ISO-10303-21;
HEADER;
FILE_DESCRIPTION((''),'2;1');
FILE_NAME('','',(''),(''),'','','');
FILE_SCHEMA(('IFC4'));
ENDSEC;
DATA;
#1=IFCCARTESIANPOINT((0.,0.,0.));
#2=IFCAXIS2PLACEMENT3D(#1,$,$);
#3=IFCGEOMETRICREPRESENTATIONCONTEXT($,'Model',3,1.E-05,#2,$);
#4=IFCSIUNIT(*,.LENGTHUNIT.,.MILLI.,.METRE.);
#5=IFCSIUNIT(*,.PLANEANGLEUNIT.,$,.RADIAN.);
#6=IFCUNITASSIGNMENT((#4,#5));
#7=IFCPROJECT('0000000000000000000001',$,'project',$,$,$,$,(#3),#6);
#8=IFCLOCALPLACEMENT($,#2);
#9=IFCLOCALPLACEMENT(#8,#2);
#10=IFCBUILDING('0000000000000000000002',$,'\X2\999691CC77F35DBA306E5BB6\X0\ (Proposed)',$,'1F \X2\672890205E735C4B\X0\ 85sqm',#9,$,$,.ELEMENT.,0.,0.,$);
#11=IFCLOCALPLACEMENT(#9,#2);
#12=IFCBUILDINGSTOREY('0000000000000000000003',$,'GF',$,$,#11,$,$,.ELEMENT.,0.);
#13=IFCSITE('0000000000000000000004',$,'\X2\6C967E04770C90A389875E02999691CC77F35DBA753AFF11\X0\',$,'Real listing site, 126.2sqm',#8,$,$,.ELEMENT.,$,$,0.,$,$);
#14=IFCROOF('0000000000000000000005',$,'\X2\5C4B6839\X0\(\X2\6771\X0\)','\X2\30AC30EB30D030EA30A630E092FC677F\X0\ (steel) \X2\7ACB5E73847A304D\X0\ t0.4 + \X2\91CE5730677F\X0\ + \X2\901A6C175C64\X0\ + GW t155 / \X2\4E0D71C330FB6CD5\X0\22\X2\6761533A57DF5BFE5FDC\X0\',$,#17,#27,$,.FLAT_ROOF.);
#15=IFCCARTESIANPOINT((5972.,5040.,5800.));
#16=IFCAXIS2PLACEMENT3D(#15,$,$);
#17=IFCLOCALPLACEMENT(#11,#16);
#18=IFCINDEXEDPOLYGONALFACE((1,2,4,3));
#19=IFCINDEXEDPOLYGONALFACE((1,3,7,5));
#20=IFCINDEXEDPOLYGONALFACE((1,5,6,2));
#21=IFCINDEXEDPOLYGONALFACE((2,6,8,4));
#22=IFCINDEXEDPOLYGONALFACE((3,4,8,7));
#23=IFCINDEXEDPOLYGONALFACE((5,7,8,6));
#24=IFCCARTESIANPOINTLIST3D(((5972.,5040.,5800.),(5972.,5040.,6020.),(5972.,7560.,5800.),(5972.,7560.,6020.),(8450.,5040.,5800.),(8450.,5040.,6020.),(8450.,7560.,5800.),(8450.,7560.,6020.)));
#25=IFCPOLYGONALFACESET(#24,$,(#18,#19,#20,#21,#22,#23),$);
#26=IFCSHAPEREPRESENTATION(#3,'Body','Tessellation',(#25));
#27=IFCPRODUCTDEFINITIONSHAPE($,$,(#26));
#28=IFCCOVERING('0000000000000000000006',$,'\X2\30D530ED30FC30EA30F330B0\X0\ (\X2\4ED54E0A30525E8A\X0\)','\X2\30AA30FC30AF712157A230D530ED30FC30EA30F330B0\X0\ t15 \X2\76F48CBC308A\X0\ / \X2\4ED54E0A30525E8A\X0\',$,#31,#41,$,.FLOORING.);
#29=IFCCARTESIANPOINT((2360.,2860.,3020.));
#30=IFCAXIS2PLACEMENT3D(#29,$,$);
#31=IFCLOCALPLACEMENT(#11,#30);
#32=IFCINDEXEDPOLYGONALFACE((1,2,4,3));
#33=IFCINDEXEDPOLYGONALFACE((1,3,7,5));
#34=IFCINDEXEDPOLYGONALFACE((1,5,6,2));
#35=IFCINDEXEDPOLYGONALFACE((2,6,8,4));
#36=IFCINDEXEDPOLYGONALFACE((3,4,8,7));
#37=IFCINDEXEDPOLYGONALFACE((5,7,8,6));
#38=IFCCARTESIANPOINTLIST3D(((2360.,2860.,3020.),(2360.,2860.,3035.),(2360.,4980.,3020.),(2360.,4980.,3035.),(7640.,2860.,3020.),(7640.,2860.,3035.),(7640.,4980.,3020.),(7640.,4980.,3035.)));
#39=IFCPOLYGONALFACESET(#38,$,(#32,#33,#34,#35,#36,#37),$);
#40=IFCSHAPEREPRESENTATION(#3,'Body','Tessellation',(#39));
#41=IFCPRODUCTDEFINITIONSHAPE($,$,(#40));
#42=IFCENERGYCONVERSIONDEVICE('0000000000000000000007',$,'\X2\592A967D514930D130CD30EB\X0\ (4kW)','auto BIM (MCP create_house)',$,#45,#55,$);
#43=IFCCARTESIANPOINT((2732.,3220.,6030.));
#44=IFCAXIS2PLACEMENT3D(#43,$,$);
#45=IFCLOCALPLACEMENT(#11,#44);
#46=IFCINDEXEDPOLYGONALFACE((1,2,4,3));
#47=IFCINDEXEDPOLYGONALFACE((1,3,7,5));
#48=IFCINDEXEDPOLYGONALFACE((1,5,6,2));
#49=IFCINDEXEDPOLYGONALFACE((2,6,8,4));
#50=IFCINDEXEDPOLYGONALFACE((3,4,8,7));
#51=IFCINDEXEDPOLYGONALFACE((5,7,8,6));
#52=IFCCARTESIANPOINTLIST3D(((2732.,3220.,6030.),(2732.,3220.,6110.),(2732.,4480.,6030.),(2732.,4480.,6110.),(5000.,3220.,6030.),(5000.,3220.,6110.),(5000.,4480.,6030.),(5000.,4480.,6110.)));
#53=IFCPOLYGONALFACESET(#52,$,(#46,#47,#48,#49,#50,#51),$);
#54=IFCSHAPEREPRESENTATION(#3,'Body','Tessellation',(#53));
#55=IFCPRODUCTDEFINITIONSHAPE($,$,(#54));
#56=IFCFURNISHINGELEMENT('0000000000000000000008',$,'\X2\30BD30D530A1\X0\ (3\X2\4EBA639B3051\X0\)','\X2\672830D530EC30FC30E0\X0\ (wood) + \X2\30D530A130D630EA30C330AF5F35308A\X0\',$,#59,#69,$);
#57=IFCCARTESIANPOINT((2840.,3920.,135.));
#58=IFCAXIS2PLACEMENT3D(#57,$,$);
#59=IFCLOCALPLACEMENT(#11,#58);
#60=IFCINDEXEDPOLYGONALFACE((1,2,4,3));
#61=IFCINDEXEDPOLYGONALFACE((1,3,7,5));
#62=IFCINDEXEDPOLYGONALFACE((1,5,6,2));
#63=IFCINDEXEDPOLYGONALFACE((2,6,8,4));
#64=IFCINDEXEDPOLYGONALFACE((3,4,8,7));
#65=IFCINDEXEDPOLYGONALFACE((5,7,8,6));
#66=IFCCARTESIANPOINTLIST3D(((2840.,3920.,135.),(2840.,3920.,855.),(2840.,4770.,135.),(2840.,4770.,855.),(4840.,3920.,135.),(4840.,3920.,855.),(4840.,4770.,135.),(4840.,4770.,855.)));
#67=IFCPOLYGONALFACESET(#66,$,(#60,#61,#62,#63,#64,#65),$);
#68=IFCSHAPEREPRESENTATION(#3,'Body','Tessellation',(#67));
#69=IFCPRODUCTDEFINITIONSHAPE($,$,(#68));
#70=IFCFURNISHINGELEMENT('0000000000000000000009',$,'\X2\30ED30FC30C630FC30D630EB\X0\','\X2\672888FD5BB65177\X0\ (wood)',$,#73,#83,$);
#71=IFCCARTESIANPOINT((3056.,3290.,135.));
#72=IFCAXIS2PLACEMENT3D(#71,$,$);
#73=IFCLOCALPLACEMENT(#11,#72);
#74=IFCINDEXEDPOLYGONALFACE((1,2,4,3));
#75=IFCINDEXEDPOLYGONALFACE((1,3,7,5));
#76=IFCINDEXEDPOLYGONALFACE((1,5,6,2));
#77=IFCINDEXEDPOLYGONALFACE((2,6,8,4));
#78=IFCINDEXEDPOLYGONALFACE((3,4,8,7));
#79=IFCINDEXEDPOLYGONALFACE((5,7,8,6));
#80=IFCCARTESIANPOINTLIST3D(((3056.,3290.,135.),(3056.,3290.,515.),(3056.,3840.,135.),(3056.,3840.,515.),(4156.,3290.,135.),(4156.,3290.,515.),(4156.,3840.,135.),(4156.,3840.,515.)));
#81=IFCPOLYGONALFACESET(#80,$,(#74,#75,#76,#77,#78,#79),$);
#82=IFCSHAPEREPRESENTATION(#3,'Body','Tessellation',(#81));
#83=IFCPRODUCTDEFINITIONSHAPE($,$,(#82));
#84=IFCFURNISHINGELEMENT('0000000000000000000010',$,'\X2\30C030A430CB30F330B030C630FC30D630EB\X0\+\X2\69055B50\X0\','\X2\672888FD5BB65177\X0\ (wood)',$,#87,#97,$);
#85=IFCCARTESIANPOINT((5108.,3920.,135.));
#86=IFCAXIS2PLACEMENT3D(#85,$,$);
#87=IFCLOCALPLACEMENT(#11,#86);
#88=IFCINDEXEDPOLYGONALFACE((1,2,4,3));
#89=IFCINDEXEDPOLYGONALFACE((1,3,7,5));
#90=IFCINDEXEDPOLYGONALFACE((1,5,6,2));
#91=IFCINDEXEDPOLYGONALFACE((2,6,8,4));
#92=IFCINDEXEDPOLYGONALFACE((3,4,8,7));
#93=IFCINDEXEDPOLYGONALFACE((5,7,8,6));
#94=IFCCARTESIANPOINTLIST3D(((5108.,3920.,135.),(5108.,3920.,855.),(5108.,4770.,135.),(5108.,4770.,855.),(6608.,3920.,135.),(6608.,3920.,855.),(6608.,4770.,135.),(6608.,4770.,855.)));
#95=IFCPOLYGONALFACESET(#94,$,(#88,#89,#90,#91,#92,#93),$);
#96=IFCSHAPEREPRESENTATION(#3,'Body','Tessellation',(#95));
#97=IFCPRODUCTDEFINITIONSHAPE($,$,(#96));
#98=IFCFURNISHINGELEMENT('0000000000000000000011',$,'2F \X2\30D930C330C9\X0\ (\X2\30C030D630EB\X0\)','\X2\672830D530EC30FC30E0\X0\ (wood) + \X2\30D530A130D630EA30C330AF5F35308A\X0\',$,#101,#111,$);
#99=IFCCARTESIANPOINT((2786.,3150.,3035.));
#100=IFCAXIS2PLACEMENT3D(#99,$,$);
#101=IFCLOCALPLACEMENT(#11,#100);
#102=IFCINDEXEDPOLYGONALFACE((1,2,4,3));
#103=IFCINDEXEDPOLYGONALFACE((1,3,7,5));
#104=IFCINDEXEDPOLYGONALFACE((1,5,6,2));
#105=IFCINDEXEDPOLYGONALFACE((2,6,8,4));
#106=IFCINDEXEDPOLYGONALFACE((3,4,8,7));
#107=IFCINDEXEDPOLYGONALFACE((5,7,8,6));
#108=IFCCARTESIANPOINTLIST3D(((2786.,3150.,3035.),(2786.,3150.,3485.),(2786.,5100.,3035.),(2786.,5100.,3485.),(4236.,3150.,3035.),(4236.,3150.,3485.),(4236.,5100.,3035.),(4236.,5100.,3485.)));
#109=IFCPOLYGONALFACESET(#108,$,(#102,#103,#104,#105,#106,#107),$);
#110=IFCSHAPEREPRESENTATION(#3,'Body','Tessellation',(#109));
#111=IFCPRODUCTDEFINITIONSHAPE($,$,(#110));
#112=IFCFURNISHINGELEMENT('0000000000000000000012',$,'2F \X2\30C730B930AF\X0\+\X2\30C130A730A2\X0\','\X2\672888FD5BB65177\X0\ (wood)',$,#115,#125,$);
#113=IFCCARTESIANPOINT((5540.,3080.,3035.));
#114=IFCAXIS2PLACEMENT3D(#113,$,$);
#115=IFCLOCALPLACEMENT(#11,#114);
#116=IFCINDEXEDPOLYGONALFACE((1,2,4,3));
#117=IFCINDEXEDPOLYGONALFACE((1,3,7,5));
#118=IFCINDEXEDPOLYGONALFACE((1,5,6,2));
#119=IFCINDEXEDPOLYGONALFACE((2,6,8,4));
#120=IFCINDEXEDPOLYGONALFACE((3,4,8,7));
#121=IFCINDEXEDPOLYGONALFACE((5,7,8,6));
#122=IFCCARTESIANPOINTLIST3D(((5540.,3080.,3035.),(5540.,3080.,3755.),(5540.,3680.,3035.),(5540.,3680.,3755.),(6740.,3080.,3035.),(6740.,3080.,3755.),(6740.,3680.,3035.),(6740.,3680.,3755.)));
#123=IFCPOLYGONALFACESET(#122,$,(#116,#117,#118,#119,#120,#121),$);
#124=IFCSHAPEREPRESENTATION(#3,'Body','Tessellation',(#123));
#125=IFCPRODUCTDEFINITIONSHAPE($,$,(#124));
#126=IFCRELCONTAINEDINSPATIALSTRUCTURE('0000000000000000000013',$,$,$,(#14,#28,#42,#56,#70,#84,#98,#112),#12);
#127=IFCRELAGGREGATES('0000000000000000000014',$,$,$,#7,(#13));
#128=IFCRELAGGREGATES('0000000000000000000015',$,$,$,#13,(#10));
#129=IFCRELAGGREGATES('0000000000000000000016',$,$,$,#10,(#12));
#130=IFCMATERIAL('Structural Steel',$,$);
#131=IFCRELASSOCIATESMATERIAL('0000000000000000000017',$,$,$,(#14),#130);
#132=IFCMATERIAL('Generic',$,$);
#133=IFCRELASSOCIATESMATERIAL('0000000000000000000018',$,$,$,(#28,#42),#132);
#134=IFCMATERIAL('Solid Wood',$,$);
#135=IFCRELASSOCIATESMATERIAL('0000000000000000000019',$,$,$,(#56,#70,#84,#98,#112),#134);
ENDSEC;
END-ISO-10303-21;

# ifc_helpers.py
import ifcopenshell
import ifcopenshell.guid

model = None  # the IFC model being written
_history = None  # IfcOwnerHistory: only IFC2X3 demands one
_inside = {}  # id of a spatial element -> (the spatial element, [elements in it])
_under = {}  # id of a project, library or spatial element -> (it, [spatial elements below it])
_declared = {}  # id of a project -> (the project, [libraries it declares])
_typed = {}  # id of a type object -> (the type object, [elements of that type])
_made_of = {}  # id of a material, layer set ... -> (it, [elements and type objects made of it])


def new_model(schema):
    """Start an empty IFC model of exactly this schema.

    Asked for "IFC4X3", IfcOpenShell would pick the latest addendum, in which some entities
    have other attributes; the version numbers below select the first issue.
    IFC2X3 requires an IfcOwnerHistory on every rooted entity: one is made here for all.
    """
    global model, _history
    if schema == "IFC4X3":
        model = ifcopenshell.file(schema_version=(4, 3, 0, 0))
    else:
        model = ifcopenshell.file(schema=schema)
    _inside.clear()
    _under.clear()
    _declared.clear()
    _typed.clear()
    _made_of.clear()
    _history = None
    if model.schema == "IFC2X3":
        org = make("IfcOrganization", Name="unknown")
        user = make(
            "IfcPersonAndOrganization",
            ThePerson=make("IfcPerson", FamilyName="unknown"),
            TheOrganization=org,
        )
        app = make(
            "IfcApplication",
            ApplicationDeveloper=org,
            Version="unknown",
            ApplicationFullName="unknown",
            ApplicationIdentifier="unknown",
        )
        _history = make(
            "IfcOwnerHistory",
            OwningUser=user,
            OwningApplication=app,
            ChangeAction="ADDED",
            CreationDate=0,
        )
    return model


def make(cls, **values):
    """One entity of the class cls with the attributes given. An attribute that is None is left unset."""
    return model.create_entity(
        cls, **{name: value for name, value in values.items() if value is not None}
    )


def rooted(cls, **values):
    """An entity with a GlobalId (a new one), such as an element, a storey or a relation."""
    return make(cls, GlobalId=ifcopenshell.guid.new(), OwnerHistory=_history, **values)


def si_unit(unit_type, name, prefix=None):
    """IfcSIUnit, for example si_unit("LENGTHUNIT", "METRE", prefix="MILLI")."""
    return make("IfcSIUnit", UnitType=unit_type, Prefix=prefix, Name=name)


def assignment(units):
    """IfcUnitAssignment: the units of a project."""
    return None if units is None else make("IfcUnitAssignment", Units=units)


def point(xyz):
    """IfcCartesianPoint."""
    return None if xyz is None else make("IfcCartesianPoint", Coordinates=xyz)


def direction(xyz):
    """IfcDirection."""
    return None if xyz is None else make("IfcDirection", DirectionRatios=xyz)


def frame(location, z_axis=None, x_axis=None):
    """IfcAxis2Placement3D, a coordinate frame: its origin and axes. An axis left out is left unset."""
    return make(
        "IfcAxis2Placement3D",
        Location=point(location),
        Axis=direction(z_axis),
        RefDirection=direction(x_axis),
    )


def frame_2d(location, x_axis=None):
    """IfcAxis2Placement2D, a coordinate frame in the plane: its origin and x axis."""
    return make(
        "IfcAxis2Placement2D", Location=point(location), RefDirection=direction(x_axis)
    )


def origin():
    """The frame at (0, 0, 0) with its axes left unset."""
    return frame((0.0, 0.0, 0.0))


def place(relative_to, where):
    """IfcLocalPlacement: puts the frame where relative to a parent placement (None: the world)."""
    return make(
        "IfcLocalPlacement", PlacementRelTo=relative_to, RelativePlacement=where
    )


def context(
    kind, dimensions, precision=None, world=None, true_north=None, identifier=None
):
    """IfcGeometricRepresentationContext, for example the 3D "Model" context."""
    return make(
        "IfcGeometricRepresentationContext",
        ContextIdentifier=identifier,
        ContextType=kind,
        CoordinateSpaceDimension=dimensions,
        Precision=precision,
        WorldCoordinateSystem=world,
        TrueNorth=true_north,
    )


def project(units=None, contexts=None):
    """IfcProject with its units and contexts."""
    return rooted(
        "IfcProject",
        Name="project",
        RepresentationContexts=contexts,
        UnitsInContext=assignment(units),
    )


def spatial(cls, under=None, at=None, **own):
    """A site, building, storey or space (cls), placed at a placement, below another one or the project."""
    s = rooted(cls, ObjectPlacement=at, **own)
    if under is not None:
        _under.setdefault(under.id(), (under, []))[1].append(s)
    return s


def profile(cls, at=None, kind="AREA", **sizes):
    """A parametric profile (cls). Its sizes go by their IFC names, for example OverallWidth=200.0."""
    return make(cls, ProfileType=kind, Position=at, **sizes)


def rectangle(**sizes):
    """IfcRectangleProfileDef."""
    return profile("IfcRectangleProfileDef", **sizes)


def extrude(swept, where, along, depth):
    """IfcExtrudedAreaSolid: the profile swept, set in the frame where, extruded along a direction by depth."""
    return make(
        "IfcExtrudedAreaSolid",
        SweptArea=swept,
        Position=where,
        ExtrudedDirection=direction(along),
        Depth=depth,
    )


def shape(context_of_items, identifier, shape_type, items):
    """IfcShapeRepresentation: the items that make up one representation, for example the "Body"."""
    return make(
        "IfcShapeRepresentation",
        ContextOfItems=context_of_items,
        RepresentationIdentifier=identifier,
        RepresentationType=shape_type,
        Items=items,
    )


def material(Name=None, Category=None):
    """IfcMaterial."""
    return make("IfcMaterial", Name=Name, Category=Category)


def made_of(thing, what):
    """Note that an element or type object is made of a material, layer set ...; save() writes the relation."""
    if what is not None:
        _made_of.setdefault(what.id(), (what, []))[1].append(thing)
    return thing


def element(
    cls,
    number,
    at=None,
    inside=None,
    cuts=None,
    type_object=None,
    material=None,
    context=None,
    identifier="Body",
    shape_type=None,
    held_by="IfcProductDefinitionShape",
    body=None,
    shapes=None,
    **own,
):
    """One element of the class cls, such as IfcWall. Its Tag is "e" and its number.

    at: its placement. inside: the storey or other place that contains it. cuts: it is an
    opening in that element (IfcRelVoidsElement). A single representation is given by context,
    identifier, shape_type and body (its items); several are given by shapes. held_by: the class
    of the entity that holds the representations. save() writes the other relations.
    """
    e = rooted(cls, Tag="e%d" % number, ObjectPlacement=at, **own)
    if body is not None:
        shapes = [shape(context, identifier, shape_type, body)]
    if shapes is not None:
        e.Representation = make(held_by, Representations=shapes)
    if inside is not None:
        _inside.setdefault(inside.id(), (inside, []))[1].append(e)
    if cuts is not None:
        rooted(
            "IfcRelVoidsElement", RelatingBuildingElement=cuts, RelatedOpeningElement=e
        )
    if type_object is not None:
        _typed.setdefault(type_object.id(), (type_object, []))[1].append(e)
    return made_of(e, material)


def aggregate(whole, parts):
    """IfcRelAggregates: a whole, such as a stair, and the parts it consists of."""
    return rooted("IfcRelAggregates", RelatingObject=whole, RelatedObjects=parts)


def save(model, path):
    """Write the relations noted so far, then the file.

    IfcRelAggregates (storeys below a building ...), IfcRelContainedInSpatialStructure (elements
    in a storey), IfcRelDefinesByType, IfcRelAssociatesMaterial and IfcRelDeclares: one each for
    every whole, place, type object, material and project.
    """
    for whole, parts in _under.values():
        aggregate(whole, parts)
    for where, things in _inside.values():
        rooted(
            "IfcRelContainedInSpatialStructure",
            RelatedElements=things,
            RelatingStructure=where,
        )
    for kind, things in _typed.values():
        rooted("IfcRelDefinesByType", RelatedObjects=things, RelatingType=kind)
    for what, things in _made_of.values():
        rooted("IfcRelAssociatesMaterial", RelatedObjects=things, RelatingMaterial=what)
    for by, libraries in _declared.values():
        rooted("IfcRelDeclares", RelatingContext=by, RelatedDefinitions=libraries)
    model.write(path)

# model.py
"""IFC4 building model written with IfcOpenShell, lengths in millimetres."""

from ifc_helpers import new_model, si_unit, frame, frame_2d, origin, place, context, project, spatial, rectangle, extrude, material, element, save


model = new_model("IFC4")

# Units and contexts
model_context = context("Model", 3, precision=1e-05, world=origin())
ifc_project = project(units=[si_unit("LENGTHUNIT", "METRE", prefix="MILLI"), si_unit("PLANEANGLEUNIT", "RADIAN")], contexts=[model_context])

# Site, building, storey
site_placement = place(None, origin())
site = spatial("IfcSite", under=ifc_project, at=site_placement, Name="沖縄県那覇市首里石嶺町１", ObjectType="Real listing site, 126.2sqm", CompositionType="ELEMENT", RefElevation=0.0)
building_placement = place(site_placement, origin())
building = spatial("IfcBuilding", under=site, at=building_placement, Name="首里石嶺の家 (Proposed)", ObjectType="1F 木造平屋 85sqm", CompositionType="ELEMENT", ElevationOfRefHeight=0.0, ElevationOfTerrain=0.0)
storey_placement = place(building_placement, origin())
storey = spatial("IfcBuildingStorey", under=building, at=storey_placement, Name="GF", CompositionType="ELEMENT", Elevation=0.0)

# Shared definitions
ifc_material_1 = material(Name="Solid Wood")

# Roof
ifc_material_2 = material(Name="Structural Steel")
roof_1_placement = place(storey_placement, frame((5972.0, 5040.0, 5800.0)))
element("IfcRoof", 1, at=roof_1_placement, inside=storey, material=ifc_material_2, Name="屋根(東)", Description="ガルバリウム鋼板 (steel) 立平葺き t0.4 + 野地板 + 通気層 + GW t155 / 不燃・法22条区域対応", PredefinedType="FLAT_ROOF", context=model_context, shape_type="SweptSolid", body=[
    extrude(rectangle(XDim=2478.0, YDim=2520.0, at=frame_2d((1239.0, 1260.0))), frame((5972.0, 5040.0, 5800.0)), (0.0, 0.0, 1.0), 220.0),
])

# Covering
ifc_material_3 = material(Name="Generic")
covering_placement = place(storey_placement, frame((2360.0, 2860.0, 3020.0)))
element("IfcCovering", 2, at=covering_placement, inside=storey, material=ifc_material_3, Name="フローリング (仕上げ床)", Description="オーク無垢フローリング t15 直貼り / 仕上げ床", PredefinedType="FLOORING", context=model_context, shape_type="SweptSolid", body=[
    extrude(rectangle(XDim=5280.0, YDim=2120.0, at=frame_2d((2640.0, 1060.0))), frame((2360.0, 2860.0, 3020.0)), (0.0, 0.0, 1.0), 15.0),
])

# Energy conversion device
energy_conversion_device_placement = place(storey_placement, frame((2732.0, 3220.0, 6030.0)))
element("IfcEnergyConversionDevice", 3, at=energy_conversion_device_placement, inside=storey, material=ifc_material_3, Name="太陽光パネル (4kW)", Description="auto BIM (MCP create_house)", context=model_context, shape_type="SweptSolid", body=[
    extrude(rectangle(XDim=2268.0, YDim=1260.0, at=frame_2d((1134.0, 630.0))), frame((2732.0, 3220.0, 6030.0)), (0.0, 0.0, 1.0), 80.0),
])

# Furnishing elements
furnishing_1_placement = place(storey_placement, frame((2840.0, 3920.0, 135.0)))
element("IfcFurnishingElement", 4, at=furnishing_1_placement, inside=storey, material=ifc_material_1, Name="ソファ (3人掛け)", Description="木フレーム (wood) + ファブリック張り", context=model_context, shape_type="SweptSolid", body=[
    extrude(rectangle(XDim=2000.0, YDim=850.0, at=frame_2d((1000.0, 425.0))), frame((2840.0, 3920.0, 135.0)), (0.0, 0.0, 1.0), 720.0),
])
furnishing_2_placement = place(storey_placement, frame((3056.0, 3290.0, 135.0)))
element("IfcFurnishingElement", 5, at=furnishing_2_placement, inside=storey, material=ifc_material_1, Name="ローテーブル", Description="木製家具 (wood)", context=model_context, shape_type="SweptSolid", body=[
    extrude(rectangle(XDim=1100.0, YDim=550.0, at=frame_2d((550.0, 275.0))), frame((3056.0, 3290.0, 135.0)), (0.0, 0.0, 1.0), 380.0),
])
furnishing_3_placement = place(storey_placement, frame((5108.0, 3920.0, 135.0)))
element("IfcFurnishingElement", 6, at=furnishing_3_placement, inside=storey, material=ifc_material_1, Name="ダイニングテーブル+椅子", Description="木製家具 (wood)", context=model_context, shape_type="SweptSolid", body=[
    extrude(rectangle(XDim=1500.0, YDim=850.0, at=frame_2d((750.0, 425.0))), frame((5108.0, 3920.0, 135.0)), (0.0, 0.0, 1.0), 720.0),
])
furnishing_4_placement = place(storey_placement, frame((2786.0, 3150.0, 3035.0)))
element("IfcFurnishingElement", 7, at=furnishing_4_placement, inside=storey, material=ifc_material_1, Name="2F ベッド (ダブル)", Description="木フレーム (wood) + ファブリック張り", context=model_context, shape_type="SweptSolid", body=[
    extrude(rectangle(XDim=1450.0, YDim=1950.0, at=frame_2d((725.0, 975.0))), frame((2786.0, 3150.0, 3035.0)), (0.0, 0.0, 1.0), 450.0),
])
furnishing_5_placement = place(storey_placement, frame((5540.0, 3080.0, 3035.0)))
element("IfcFurnishingElement", 8, at=furnishing_5_placement, inside=storey, material=ifc_material_1, Name="2F デスク+チェア", Description="木製家具 (wood)", context=model_context, shape_type="SweptSolid", body=[
    extrude(rectangle(XDim=1200.0, YDim=600.0, at=frame_2d((600.0, 300.0))), frame((5540.0, 3080.0, 3035.0)), (0.0, 0.0, 1.0), 720.0),
])

save(model, "model.ifc")
